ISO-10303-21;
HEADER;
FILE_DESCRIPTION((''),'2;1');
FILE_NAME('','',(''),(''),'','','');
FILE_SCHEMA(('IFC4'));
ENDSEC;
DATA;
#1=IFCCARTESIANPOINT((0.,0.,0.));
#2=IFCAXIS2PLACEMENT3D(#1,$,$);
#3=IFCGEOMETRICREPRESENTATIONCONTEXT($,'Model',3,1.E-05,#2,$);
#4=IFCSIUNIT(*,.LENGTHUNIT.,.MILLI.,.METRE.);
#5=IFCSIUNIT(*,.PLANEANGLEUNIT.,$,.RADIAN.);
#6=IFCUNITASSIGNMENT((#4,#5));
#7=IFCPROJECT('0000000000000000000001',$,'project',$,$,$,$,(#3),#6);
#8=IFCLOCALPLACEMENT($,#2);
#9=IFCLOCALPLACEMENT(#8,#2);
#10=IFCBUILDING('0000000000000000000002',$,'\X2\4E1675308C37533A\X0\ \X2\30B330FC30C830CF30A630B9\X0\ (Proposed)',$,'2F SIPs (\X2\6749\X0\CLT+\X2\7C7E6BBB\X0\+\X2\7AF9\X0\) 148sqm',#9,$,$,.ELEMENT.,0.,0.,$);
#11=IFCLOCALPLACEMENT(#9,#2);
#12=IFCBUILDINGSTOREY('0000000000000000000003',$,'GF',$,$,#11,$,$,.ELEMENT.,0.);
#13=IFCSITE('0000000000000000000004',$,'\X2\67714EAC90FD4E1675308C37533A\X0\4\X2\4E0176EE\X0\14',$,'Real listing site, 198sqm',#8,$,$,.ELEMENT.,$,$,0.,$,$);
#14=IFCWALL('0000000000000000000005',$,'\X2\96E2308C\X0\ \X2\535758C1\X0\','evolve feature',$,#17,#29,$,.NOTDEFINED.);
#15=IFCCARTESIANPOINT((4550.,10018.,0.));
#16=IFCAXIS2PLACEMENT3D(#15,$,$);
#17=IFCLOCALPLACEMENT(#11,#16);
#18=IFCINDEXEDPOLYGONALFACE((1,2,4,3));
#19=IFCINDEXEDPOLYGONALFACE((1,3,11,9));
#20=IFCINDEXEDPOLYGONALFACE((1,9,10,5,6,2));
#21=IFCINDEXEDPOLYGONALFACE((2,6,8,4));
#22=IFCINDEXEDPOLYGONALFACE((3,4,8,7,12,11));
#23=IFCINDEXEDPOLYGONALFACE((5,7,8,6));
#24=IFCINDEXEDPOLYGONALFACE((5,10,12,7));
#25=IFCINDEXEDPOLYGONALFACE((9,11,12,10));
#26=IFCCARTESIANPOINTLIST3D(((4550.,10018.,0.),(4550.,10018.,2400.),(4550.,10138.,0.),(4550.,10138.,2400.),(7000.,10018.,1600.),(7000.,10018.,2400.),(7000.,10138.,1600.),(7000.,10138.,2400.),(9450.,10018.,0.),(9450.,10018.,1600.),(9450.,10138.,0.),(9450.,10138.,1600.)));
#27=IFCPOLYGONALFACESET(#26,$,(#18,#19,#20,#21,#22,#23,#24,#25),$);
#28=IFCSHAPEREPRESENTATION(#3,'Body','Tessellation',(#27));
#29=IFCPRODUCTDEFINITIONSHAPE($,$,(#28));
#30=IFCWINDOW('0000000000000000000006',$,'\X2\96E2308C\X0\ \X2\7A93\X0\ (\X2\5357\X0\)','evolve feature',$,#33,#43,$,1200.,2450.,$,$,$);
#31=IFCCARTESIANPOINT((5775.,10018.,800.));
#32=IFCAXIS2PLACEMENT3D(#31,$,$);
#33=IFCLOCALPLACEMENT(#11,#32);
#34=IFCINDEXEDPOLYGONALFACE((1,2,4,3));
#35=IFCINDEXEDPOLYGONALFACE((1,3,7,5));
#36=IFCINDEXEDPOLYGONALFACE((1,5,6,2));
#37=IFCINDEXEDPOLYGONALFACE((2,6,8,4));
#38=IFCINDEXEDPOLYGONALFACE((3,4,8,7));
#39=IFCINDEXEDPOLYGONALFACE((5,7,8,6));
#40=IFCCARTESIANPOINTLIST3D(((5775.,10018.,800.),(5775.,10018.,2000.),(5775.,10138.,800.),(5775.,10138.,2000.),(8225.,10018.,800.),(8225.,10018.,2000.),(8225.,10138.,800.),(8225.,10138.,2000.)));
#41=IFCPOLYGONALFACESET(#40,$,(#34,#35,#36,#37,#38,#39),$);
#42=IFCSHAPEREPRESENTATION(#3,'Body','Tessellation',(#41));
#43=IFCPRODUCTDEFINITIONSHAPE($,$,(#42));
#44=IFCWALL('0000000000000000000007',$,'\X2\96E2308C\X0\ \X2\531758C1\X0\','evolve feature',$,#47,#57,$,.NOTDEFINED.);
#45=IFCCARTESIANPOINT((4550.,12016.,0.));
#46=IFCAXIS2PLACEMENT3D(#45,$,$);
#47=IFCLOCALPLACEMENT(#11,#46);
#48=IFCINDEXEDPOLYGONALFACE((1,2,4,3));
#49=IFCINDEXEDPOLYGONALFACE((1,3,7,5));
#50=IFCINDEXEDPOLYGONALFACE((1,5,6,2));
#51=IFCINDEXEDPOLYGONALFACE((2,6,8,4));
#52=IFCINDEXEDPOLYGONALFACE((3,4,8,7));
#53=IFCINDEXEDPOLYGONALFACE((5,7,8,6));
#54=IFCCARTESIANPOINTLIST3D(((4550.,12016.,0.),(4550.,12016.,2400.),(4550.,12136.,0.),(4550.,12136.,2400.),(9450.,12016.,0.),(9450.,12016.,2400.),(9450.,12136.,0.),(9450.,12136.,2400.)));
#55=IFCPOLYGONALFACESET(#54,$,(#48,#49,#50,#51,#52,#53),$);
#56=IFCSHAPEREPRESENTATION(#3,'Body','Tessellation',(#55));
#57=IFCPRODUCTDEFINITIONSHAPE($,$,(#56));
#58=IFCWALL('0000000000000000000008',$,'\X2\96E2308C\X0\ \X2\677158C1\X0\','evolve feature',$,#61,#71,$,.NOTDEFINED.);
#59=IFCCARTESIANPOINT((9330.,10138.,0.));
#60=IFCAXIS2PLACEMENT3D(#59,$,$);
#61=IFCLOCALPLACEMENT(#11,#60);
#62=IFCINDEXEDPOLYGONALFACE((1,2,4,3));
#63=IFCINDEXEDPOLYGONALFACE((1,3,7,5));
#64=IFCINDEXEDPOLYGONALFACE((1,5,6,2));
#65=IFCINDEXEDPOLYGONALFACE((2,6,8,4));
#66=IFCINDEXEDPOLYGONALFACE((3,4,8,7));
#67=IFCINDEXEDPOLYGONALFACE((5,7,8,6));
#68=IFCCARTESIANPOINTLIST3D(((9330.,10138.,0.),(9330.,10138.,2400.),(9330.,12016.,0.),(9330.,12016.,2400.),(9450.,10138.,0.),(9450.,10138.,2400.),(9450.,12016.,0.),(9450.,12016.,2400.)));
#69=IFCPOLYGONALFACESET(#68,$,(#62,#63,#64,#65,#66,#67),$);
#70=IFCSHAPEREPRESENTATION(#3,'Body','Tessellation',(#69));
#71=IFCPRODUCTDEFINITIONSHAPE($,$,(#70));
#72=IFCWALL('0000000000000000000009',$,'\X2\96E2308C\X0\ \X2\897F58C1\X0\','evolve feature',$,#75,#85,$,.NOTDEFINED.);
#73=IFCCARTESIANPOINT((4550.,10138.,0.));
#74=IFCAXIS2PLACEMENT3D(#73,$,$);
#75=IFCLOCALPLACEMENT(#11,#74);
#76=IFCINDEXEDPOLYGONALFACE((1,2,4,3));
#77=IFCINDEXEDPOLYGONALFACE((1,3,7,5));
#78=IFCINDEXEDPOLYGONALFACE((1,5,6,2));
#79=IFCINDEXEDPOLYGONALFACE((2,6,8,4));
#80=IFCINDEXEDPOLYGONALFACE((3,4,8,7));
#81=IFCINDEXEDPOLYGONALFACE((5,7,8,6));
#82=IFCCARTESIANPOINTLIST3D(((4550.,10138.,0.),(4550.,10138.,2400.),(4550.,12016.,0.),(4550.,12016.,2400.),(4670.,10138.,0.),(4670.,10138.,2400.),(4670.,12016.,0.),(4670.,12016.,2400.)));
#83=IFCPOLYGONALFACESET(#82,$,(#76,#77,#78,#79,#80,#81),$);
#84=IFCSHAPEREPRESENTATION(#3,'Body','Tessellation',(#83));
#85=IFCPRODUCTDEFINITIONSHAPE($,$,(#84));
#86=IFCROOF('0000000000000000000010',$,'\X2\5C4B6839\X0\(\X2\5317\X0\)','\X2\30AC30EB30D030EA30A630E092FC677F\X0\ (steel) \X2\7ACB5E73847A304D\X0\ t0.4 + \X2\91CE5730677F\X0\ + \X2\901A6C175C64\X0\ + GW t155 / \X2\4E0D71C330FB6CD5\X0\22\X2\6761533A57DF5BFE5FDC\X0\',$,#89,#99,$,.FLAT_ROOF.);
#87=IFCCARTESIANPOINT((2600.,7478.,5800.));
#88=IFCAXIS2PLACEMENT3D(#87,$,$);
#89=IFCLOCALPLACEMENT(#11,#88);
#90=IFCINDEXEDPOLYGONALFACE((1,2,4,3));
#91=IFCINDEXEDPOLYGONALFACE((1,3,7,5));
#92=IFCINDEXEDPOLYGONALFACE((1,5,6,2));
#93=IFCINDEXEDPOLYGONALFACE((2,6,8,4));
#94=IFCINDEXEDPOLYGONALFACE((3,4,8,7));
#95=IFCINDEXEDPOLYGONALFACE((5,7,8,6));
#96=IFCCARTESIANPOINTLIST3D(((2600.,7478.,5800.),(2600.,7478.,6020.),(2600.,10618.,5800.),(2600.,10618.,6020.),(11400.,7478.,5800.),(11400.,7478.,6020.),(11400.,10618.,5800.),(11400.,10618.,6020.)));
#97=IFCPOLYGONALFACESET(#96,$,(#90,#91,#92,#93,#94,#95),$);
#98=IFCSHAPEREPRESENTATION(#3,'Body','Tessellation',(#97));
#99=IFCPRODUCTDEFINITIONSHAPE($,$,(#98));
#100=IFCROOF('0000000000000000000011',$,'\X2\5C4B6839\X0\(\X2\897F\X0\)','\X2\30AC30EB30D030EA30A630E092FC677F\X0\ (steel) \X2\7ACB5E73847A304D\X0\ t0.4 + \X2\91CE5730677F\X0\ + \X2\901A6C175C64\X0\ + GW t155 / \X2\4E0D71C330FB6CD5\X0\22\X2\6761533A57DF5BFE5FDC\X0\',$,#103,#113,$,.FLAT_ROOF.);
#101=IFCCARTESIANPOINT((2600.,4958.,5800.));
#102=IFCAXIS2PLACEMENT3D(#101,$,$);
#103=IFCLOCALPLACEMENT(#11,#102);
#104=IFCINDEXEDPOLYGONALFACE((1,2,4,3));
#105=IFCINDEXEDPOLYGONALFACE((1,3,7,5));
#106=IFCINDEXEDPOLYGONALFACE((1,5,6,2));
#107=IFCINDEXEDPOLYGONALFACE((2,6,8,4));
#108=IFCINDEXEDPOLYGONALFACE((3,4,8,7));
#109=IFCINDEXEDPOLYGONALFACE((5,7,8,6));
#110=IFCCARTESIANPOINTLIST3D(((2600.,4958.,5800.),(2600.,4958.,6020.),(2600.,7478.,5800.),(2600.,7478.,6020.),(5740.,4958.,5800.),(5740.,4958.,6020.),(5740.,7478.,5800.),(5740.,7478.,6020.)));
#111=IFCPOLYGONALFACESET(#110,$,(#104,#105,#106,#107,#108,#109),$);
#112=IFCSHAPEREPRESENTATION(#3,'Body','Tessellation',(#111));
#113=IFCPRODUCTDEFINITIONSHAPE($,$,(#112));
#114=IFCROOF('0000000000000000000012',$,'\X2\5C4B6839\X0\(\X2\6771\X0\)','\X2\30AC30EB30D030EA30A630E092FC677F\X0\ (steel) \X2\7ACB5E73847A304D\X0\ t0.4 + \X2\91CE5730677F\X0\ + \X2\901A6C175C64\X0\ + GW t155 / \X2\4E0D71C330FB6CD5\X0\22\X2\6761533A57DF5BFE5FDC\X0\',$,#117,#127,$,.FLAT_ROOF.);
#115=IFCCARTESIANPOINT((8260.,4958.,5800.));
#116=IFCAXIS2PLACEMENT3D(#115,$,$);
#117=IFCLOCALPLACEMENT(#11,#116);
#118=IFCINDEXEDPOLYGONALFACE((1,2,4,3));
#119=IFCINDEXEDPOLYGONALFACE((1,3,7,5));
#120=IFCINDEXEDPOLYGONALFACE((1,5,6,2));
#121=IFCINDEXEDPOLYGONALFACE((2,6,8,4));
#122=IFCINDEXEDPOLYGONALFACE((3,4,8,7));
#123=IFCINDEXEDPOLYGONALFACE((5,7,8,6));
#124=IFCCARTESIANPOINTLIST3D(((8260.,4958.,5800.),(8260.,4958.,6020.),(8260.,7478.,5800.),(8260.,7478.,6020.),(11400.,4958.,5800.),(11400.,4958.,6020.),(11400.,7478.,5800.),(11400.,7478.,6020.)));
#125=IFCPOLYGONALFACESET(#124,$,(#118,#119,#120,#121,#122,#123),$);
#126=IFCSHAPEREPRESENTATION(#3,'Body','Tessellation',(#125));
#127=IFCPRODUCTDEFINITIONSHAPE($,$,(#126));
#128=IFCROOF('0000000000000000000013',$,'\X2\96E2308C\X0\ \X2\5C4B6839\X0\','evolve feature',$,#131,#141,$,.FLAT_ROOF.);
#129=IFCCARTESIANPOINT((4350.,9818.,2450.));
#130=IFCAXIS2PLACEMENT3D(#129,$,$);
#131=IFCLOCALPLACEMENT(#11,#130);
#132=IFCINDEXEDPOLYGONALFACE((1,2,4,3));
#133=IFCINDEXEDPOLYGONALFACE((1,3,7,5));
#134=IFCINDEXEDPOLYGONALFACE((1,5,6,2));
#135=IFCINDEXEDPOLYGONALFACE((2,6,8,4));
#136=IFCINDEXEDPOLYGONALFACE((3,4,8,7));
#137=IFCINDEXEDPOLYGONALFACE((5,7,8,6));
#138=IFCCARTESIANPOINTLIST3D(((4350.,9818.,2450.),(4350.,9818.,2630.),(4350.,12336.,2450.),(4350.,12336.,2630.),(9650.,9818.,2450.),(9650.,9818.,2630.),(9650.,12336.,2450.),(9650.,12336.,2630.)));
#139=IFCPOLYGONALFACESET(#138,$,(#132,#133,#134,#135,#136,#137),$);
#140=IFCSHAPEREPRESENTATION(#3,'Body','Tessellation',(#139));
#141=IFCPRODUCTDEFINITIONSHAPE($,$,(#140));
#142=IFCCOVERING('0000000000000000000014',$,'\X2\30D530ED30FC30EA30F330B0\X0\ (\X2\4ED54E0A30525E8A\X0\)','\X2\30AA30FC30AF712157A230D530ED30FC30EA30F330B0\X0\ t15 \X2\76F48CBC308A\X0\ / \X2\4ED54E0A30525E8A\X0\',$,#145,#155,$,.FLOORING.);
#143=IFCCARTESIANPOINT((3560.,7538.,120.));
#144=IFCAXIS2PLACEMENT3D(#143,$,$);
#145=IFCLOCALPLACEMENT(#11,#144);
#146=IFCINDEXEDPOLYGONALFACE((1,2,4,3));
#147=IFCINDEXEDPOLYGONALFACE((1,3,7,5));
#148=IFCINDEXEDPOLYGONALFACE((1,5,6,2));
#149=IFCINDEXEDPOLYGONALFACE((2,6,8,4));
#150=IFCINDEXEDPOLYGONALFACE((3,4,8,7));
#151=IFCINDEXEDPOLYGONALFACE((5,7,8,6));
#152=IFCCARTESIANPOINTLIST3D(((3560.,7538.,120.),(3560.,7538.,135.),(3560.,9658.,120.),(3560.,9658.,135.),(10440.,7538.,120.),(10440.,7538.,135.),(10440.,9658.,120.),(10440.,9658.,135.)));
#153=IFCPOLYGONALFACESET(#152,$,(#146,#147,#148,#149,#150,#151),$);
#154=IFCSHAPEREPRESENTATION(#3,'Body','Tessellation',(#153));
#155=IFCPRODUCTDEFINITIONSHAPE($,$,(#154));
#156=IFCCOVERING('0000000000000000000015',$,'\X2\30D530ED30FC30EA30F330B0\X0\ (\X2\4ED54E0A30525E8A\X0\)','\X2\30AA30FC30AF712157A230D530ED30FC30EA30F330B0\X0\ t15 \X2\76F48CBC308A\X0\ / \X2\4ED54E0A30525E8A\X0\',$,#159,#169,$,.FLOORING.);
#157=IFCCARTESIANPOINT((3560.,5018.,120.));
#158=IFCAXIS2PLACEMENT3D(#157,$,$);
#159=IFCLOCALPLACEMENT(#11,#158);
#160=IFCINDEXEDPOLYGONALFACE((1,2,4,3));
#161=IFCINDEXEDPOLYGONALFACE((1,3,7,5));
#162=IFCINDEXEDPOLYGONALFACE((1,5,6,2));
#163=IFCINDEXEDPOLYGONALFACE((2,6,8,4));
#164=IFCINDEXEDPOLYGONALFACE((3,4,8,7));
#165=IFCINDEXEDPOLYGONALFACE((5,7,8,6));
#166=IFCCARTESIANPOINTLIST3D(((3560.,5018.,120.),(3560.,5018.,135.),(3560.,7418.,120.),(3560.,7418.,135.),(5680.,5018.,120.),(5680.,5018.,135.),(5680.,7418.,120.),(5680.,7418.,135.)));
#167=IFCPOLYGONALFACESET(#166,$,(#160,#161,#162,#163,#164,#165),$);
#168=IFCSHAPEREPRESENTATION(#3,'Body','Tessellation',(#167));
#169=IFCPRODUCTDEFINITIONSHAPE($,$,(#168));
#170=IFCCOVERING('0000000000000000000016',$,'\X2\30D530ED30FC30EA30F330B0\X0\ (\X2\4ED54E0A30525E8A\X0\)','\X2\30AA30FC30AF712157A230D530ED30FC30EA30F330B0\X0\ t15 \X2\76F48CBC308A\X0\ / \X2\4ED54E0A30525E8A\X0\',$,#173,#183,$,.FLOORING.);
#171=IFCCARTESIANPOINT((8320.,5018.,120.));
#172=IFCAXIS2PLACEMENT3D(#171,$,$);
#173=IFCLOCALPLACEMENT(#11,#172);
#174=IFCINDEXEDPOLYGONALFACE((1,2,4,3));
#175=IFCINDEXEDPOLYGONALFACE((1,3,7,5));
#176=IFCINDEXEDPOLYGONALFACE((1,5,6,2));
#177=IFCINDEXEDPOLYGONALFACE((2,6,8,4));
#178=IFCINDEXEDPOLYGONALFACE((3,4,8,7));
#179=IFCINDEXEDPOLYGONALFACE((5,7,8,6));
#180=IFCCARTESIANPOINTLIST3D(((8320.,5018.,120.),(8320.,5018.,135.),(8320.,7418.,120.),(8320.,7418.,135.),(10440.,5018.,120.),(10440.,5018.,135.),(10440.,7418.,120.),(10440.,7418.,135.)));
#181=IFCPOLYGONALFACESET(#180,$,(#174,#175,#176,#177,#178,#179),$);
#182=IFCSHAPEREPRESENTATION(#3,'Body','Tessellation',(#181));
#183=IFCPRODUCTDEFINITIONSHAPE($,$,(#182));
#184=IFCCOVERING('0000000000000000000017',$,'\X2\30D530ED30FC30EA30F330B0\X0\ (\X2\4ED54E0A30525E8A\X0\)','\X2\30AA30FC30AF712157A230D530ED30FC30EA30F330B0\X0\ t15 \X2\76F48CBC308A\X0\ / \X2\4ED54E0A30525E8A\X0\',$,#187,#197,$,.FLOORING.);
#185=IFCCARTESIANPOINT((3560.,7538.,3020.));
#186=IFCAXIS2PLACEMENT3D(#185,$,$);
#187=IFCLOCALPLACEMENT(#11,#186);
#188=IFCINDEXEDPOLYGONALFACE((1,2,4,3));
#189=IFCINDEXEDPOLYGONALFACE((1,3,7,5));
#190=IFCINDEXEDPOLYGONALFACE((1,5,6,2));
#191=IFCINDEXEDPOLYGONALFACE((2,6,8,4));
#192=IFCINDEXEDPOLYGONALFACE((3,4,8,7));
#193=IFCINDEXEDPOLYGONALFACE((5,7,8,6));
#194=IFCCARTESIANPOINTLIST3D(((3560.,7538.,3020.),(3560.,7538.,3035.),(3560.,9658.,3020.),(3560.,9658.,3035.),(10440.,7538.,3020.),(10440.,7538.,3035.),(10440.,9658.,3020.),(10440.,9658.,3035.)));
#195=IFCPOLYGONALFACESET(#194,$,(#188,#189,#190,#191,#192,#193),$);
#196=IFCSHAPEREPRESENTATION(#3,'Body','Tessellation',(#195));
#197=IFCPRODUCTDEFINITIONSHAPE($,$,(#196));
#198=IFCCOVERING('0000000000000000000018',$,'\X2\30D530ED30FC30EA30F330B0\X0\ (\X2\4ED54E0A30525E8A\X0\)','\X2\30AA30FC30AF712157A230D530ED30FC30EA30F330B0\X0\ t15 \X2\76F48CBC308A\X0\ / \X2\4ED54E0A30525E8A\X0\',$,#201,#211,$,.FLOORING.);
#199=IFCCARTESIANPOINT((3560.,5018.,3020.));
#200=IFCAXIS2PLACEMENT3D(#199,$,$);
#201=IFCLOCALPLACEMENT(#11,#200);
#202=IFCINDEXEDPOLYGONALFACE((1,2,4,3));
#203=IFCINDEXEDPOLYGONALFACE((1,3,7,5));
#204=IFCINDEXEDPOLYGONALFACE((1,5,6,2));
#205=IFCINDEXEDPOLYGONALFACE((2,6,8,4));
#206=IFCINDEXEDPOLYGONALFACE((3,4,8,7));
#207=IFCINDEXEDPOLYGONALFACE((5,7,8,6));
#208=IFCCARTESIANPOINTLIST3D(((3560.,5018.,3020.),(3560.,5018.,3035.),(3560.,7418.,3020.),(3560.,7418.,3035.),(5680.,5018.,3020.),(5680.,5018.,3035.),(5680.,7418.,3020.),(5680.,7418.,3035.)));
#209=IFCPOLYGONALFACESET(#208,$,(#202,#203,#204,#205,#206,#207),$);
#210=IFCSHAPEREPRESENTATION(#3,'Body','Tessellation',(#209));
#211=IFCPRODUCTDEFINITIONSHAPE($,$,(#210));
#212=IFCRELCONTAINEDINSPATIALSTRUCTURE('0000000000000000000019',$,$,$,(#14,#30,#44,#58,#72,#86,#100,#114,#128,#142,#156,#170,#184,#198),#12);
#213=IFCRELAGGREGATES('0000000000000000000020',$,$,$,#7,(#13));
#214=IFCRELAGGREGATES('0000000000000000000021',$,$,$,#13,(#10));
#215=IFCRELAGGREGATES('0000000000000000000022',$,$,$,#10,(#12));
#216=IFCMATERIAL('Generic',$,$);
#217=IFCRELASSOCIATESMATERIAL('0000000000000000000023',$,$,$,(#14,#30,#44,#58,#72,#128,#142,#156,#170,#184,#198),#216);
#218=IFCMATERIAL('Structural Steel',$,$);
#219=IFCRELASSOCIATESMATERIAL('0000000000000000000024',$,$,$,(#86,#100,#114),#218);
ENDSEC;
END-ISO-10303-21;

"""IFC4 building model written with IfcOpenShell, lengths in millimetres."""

from ifc_helpers import new_model, si_unit, frame, frame_2d, origin, place, context, project, spatial, rectangle, extrude, material, element, fill, save


model = new_model("IFC4")

# Units and contexts
model_context = context("Model", 3, precision=1e-05, world=origin())
ifc_project = project(units=[si_unit("LENGTHUNIT", "METRE", prefix="MILLI"), si_unit("PLANEANGLEUNIT", "RADIAN")], contexts=[model_context])

# Site, building, storey
site_placement = place(None, origin())
site = spatial("IfcSite", under=ifc_project, at=site_placement, Name="東京都世田谷区4丁目14", ObjectType="Real listing site, 198sqm", CompositionType="ELEMENT", RefElevation=0.0)
building_placement = place(site_placement, origin())
building = spatial("IfcBuilding", under=site, at=building_placement, Name="世田谷区 コートハウス (Proposed)", ObjectType="2F SIPs (杉CLT+籾殻+竹) 148sqm", CompositionType="ELEMENT", ElevationOfRefHeight=0.0, ElevationOfTerrain=0.0)
storey_placement = place(building_placement, origin())
storey = spatial("IfcBuildingStorey", under=building, at=storey_placement, Name="GF", CompositionType="ELEMENT", Elevation=0.0)

# Shared definitions
ifc_material_1 = material(Name="Generic")

# Wall, opening, window
wall_1_placement = place(storey_placement, frame((4550.0, 10018.0, 0.0)))
wall_1 = element("IfcWall", 1, at=wall_1_placement, inside=storey, material=ifc_material_1, Name="離れ 南壁", Description="evolve feature", PredefinedType="NOTDEFINED", context=model_context, shape_type="SweptSolid", body=[
    extrude(rectangle(XDim=4900.0, YDim=120.0, at=frame_2d((2450.0, 60.0))), frame((4550.0, 10018.0, 0.0)), (0.0, 0.0, 1.0), 2400.0),
])
opening_1_placement = place(storey_placement, frame((5775.0, 10018.0, 800.0)))
opening_1 = element("IfcOpeningElement", 2, at=opening_1_placement, cuts=wall_1, PredefinedType="NOTDEFINED", context=model_context, shape_type="SweptSolid", body=[
    extrude(rectangle(XDim=2450.0, YDim=120.0, at=frame_2d((1225.0, 60.0))), frame((5775.0, 10018.0, 800.0)), (0.0, 0.0, 1.0), 1200.0),
])
window_1_placement = place(storey_placement, frame((5775.0, 10018.0, 800.0)))
window_1 = element("IfcWindow", 3, at=window_1_placement, inside=storey, material=ifc_material_1, Name="離れ 窓 (南)", Description="evolve feature", OverallHeight=1200.0, OverallWidth=2450.0, context=model_context, shape_type="SweptSolid", body=[
    extrude(rectangle(XDim=2450.0, YDim=120.0, at=frame_2d((1225.0, 60.0))), frame((5775.0, 10018.0, 800.0)), (0.0, 0.0, 1.0), 1200.0),
])
fill(opening_1, window_1)

# Walls
wall_2_placement = place(storey_placement, frame((4550.0, 12016.0, 0.0)))
element("IfcWall", 4, at=wall_2_placement, inside=storey, material=ifc_material_1, Name="離れ 北壁", Description="evolve feature", PredefinedType="NOTDEFINED", context=model_context, shape_type="SweptSolid", body=[
    extrude(rectangle(XDim=4900.0, YDim=120.0, at=frame_2d((2450.0, 60.0))), frame((4550.0, 12016.0, 0.0)), (0.0, 0.0, 1.0), 2400.0),
])
wall_3_placement = place(storey_placement, frame((9330.0, 10138.0, 0.0)))
element("IfcWall", 5, at=wall_3_placement, inside=storey, material=ifc_material_1, Name="離れ 東壁", Description="evolve feature", PredefinedType="NOTDEFINED", context=model_context, shape_type="SweptSolid", body=[
    extrude(rectangle(XDim=120.0, YDim=1878.0, at=frame_2d((60.0, 939.0))), frame((9330.0, 10138.0, 0.0)), (0.0, 0.0, 1.0), 2400.0),
])
wall_4_placement = place(storey_placement, frame((4550.0, 10138.0, 0.0)))
element("IfcWall", 6, at=wall_4_placement, inside=storey, material=ifc_material_1, Name="離れ 西壁", Description="evolve feature", PredefinedType="NOTDEFINED", context=model_context, shape_type="SweptSolid", body=[
    extrude(rectangle(XDim=120.0, YDim=1878.0, at=frame_2d((60.0, 939.0))), frame((4550.0, 10138.0, 0.0)), (0.0, 0.0, 1.0), 2400.0),
])

# Roofs
ifc_material_2 = material(Name="Structural Steel")
for number, where, name in (
    (7, (2600.0, 7478.0, 5800.0), "屋根(北)"),
):
    element("IfcRoof", number, at=place(storey_placement, frame(where)), inside=storey, material=ifc_material_2, Name=name, Description="ガルバリウム鋼板 (steel) 立平葺き t0.4 + 野地板 + 通気層 + GW t155 / 不燃・法22条区域対応", PredefinedType="FLAT_ROOF", context=model_context, shape_type="SweptSolid", body=[
        extrude(rectangle(XDim=8800.0, YDim=3140.0, at=frame_2d((4400.0, 1570.0))), frame((2600.0, 7478.0, 5800.0)), (0.0, 0.0, 1.0), 220.0),
    ])
roof_1_placement = place(storey_placement, frame((2600.0, 4958.0, 5800.0)))
element("IfcRoof", 8, at=roof_1_placement, inside=storey, material=ifc_material_2, Name="屋根(西)", Description="ガルバリウム鋼板 (steel) 立平葺き t0.4 + 野地板 + 通気層 + GW t155 / 不燃・法22条区域対応", PredefinedType="FLAT_ROOF", context=model_context, shape_type="SweptSolid", body=[
    extrude(rectangle(XDim=3140.0, YDim=2520.0, at=frame_2d((1570.0, 1260.0))), frame((2600.0, 4958.0, 5800.0)), (0.0, 0.0, 1.0), 220.0),
])
roof_2_placement = place(storey_placement, frame((8260.0, 4958.0, 5800.0)))
element("IfcRoof", 9, at=roof_2_placement, inside=storey, material=ifc_material_2, Name="屋根(東)", Description="ガルバリウム鋼板 (steel) 立平葺き t0.4 + 野地板 + 通気層 + GW t155 / 不燃・法22条区域対応", PredefinedType="FLAT_ROOF", context=model_context, shape_type="SweptSolid", body=[
    extrude(rectangle(XDim=3140.0, YDim=2520.0, at=frame_2d((1570.0, 1260.0))), frame((8260.0, 4958.0, 5800.0)), (0.0, 0.0, 1.0), 220.0),
])
roof_3_placement = place(storey_placement, frame((4350.0, 9818.0, 2450.0)))
element("IfcRoof", 10, at=roof_3_placement, inside=storey, material=ifc_material_1, Name="離れ 屋根", Description="evolve feature", PredefinedType="FLAT_ROOF", context=model_context, shape_type="SweptSolid", body=[
    extrude(rectangle(XDim=5300.0, YDim=2518.0, at=frame_2d((2650.0, 1259.0))), frame((4350.0, 9818.0, 2450.0)), (0.0, 0.0, 1.0), 180.0),
])

# Coverings
covering_1_placement = place(storey_placement, frame((3560.0, 7538.0, 120.0)))
element("IfcCovering", 11, at=covering_1_placement, inside=storey, material=ifc_material_1, Name="フローリング (仕上げ床)", Description="オーク無垢フローリング t15 直貼り / 仕上げ床", PredefinedType="FLOORING", context=model_context, shape_type="SweptSolid", body=[
    extrude(rectangle(XDim=6880.0, YDim=2120.0, at=frame_2d((3440.0, 1060.0))), frame((3560.0, 7538.0, 120.0)), (0.0, 0.0, 1.0), 15.0),
])
covering_2_placement = place(storey_placement, frame((3560.0, 5018.0, 120.0)))
element("IfcCovering", 12, at=covering_2_placement, inside=storey, material=ifc_material_1, Name="フローリング (仕上げ床)", Description="オーク無垢フローリング t15 直貼り / 仕上げ床", PredefinedType="FLOORING", context=model_context, shape_type="SweptSolid", body=[
    extrude(rectangle(XDim=2120.0, YDim=2400.0, at=frame_2d((1060.0, 1200.0))), frame((3560.0, 5018.0, 120.0)), (0.0, 0.0, 1.0), 15.0),
])
covering_3_placement = place(storey_placement, frame((8320.0, 5018.0, 120.0)))
element("IfcCovering", 13, at=covering_3_placement, inside=storey, material=ifc_material_1, Name="フローリング (仕上げ床)", Description="オーク無垢フローリング t15 直貼り / 仕上げ床", PredefinedType="FLOORING", context=model_context, shape_type="SweptSolid", body=[
    extrude(rectangle(XDim=2120.0, YDim=2400.0, at=frame_2d((1060.0, 1200.0))), frame((8320.0, 5018.0, 120.0)), (0.0, 0.0, 1.0), 15.0),
])
covering_4_placement = place(storey_placement, frame((3560.0, 7538.0, 3020.0)))
element("IfcCovering", 14, at=covering_4_placement, inside=storey, material=ifc_material_1, Name="フローリング (仕上げ床)", Description="オーク無垢フローリング t15 直貼り / 仕上げ床", PredefinedType="FLOORING", context=model_context, shape_type="SweptSolid", body=[
    extrude(rectangle(XDim=6880.0, YDim=2120.0, at=frame_2d((3440.0, 1060.0))), frame((3560.0, 7538.0, 3020.0)), (0.0, 0.0, 1.0), 15.0),
])
covering_5_placement = place(storey_placement, frame((3560.0, 5018.0, 3020.0)))
element("IfcCovering", 15, at=covering_5_placement, inside=storey, material=ifc_material_1, Name="フローリング (仕上げ床)", Description="オーク無垢フローリング t15 直貼り / 仕上げ床", PredefinedType="FLOORING", context=model_context, shape_type="SweptSolid", body=[
    extrude(rectangle(XDim=2120.0, YDim=2400.0, at=frame_2d((1060.0, 1200.0))), frame((3560.0, 5018.0, 3020.0)), (0.0, 0.0, 1.0), 15.0),
])

save(model, "model.ifc")
